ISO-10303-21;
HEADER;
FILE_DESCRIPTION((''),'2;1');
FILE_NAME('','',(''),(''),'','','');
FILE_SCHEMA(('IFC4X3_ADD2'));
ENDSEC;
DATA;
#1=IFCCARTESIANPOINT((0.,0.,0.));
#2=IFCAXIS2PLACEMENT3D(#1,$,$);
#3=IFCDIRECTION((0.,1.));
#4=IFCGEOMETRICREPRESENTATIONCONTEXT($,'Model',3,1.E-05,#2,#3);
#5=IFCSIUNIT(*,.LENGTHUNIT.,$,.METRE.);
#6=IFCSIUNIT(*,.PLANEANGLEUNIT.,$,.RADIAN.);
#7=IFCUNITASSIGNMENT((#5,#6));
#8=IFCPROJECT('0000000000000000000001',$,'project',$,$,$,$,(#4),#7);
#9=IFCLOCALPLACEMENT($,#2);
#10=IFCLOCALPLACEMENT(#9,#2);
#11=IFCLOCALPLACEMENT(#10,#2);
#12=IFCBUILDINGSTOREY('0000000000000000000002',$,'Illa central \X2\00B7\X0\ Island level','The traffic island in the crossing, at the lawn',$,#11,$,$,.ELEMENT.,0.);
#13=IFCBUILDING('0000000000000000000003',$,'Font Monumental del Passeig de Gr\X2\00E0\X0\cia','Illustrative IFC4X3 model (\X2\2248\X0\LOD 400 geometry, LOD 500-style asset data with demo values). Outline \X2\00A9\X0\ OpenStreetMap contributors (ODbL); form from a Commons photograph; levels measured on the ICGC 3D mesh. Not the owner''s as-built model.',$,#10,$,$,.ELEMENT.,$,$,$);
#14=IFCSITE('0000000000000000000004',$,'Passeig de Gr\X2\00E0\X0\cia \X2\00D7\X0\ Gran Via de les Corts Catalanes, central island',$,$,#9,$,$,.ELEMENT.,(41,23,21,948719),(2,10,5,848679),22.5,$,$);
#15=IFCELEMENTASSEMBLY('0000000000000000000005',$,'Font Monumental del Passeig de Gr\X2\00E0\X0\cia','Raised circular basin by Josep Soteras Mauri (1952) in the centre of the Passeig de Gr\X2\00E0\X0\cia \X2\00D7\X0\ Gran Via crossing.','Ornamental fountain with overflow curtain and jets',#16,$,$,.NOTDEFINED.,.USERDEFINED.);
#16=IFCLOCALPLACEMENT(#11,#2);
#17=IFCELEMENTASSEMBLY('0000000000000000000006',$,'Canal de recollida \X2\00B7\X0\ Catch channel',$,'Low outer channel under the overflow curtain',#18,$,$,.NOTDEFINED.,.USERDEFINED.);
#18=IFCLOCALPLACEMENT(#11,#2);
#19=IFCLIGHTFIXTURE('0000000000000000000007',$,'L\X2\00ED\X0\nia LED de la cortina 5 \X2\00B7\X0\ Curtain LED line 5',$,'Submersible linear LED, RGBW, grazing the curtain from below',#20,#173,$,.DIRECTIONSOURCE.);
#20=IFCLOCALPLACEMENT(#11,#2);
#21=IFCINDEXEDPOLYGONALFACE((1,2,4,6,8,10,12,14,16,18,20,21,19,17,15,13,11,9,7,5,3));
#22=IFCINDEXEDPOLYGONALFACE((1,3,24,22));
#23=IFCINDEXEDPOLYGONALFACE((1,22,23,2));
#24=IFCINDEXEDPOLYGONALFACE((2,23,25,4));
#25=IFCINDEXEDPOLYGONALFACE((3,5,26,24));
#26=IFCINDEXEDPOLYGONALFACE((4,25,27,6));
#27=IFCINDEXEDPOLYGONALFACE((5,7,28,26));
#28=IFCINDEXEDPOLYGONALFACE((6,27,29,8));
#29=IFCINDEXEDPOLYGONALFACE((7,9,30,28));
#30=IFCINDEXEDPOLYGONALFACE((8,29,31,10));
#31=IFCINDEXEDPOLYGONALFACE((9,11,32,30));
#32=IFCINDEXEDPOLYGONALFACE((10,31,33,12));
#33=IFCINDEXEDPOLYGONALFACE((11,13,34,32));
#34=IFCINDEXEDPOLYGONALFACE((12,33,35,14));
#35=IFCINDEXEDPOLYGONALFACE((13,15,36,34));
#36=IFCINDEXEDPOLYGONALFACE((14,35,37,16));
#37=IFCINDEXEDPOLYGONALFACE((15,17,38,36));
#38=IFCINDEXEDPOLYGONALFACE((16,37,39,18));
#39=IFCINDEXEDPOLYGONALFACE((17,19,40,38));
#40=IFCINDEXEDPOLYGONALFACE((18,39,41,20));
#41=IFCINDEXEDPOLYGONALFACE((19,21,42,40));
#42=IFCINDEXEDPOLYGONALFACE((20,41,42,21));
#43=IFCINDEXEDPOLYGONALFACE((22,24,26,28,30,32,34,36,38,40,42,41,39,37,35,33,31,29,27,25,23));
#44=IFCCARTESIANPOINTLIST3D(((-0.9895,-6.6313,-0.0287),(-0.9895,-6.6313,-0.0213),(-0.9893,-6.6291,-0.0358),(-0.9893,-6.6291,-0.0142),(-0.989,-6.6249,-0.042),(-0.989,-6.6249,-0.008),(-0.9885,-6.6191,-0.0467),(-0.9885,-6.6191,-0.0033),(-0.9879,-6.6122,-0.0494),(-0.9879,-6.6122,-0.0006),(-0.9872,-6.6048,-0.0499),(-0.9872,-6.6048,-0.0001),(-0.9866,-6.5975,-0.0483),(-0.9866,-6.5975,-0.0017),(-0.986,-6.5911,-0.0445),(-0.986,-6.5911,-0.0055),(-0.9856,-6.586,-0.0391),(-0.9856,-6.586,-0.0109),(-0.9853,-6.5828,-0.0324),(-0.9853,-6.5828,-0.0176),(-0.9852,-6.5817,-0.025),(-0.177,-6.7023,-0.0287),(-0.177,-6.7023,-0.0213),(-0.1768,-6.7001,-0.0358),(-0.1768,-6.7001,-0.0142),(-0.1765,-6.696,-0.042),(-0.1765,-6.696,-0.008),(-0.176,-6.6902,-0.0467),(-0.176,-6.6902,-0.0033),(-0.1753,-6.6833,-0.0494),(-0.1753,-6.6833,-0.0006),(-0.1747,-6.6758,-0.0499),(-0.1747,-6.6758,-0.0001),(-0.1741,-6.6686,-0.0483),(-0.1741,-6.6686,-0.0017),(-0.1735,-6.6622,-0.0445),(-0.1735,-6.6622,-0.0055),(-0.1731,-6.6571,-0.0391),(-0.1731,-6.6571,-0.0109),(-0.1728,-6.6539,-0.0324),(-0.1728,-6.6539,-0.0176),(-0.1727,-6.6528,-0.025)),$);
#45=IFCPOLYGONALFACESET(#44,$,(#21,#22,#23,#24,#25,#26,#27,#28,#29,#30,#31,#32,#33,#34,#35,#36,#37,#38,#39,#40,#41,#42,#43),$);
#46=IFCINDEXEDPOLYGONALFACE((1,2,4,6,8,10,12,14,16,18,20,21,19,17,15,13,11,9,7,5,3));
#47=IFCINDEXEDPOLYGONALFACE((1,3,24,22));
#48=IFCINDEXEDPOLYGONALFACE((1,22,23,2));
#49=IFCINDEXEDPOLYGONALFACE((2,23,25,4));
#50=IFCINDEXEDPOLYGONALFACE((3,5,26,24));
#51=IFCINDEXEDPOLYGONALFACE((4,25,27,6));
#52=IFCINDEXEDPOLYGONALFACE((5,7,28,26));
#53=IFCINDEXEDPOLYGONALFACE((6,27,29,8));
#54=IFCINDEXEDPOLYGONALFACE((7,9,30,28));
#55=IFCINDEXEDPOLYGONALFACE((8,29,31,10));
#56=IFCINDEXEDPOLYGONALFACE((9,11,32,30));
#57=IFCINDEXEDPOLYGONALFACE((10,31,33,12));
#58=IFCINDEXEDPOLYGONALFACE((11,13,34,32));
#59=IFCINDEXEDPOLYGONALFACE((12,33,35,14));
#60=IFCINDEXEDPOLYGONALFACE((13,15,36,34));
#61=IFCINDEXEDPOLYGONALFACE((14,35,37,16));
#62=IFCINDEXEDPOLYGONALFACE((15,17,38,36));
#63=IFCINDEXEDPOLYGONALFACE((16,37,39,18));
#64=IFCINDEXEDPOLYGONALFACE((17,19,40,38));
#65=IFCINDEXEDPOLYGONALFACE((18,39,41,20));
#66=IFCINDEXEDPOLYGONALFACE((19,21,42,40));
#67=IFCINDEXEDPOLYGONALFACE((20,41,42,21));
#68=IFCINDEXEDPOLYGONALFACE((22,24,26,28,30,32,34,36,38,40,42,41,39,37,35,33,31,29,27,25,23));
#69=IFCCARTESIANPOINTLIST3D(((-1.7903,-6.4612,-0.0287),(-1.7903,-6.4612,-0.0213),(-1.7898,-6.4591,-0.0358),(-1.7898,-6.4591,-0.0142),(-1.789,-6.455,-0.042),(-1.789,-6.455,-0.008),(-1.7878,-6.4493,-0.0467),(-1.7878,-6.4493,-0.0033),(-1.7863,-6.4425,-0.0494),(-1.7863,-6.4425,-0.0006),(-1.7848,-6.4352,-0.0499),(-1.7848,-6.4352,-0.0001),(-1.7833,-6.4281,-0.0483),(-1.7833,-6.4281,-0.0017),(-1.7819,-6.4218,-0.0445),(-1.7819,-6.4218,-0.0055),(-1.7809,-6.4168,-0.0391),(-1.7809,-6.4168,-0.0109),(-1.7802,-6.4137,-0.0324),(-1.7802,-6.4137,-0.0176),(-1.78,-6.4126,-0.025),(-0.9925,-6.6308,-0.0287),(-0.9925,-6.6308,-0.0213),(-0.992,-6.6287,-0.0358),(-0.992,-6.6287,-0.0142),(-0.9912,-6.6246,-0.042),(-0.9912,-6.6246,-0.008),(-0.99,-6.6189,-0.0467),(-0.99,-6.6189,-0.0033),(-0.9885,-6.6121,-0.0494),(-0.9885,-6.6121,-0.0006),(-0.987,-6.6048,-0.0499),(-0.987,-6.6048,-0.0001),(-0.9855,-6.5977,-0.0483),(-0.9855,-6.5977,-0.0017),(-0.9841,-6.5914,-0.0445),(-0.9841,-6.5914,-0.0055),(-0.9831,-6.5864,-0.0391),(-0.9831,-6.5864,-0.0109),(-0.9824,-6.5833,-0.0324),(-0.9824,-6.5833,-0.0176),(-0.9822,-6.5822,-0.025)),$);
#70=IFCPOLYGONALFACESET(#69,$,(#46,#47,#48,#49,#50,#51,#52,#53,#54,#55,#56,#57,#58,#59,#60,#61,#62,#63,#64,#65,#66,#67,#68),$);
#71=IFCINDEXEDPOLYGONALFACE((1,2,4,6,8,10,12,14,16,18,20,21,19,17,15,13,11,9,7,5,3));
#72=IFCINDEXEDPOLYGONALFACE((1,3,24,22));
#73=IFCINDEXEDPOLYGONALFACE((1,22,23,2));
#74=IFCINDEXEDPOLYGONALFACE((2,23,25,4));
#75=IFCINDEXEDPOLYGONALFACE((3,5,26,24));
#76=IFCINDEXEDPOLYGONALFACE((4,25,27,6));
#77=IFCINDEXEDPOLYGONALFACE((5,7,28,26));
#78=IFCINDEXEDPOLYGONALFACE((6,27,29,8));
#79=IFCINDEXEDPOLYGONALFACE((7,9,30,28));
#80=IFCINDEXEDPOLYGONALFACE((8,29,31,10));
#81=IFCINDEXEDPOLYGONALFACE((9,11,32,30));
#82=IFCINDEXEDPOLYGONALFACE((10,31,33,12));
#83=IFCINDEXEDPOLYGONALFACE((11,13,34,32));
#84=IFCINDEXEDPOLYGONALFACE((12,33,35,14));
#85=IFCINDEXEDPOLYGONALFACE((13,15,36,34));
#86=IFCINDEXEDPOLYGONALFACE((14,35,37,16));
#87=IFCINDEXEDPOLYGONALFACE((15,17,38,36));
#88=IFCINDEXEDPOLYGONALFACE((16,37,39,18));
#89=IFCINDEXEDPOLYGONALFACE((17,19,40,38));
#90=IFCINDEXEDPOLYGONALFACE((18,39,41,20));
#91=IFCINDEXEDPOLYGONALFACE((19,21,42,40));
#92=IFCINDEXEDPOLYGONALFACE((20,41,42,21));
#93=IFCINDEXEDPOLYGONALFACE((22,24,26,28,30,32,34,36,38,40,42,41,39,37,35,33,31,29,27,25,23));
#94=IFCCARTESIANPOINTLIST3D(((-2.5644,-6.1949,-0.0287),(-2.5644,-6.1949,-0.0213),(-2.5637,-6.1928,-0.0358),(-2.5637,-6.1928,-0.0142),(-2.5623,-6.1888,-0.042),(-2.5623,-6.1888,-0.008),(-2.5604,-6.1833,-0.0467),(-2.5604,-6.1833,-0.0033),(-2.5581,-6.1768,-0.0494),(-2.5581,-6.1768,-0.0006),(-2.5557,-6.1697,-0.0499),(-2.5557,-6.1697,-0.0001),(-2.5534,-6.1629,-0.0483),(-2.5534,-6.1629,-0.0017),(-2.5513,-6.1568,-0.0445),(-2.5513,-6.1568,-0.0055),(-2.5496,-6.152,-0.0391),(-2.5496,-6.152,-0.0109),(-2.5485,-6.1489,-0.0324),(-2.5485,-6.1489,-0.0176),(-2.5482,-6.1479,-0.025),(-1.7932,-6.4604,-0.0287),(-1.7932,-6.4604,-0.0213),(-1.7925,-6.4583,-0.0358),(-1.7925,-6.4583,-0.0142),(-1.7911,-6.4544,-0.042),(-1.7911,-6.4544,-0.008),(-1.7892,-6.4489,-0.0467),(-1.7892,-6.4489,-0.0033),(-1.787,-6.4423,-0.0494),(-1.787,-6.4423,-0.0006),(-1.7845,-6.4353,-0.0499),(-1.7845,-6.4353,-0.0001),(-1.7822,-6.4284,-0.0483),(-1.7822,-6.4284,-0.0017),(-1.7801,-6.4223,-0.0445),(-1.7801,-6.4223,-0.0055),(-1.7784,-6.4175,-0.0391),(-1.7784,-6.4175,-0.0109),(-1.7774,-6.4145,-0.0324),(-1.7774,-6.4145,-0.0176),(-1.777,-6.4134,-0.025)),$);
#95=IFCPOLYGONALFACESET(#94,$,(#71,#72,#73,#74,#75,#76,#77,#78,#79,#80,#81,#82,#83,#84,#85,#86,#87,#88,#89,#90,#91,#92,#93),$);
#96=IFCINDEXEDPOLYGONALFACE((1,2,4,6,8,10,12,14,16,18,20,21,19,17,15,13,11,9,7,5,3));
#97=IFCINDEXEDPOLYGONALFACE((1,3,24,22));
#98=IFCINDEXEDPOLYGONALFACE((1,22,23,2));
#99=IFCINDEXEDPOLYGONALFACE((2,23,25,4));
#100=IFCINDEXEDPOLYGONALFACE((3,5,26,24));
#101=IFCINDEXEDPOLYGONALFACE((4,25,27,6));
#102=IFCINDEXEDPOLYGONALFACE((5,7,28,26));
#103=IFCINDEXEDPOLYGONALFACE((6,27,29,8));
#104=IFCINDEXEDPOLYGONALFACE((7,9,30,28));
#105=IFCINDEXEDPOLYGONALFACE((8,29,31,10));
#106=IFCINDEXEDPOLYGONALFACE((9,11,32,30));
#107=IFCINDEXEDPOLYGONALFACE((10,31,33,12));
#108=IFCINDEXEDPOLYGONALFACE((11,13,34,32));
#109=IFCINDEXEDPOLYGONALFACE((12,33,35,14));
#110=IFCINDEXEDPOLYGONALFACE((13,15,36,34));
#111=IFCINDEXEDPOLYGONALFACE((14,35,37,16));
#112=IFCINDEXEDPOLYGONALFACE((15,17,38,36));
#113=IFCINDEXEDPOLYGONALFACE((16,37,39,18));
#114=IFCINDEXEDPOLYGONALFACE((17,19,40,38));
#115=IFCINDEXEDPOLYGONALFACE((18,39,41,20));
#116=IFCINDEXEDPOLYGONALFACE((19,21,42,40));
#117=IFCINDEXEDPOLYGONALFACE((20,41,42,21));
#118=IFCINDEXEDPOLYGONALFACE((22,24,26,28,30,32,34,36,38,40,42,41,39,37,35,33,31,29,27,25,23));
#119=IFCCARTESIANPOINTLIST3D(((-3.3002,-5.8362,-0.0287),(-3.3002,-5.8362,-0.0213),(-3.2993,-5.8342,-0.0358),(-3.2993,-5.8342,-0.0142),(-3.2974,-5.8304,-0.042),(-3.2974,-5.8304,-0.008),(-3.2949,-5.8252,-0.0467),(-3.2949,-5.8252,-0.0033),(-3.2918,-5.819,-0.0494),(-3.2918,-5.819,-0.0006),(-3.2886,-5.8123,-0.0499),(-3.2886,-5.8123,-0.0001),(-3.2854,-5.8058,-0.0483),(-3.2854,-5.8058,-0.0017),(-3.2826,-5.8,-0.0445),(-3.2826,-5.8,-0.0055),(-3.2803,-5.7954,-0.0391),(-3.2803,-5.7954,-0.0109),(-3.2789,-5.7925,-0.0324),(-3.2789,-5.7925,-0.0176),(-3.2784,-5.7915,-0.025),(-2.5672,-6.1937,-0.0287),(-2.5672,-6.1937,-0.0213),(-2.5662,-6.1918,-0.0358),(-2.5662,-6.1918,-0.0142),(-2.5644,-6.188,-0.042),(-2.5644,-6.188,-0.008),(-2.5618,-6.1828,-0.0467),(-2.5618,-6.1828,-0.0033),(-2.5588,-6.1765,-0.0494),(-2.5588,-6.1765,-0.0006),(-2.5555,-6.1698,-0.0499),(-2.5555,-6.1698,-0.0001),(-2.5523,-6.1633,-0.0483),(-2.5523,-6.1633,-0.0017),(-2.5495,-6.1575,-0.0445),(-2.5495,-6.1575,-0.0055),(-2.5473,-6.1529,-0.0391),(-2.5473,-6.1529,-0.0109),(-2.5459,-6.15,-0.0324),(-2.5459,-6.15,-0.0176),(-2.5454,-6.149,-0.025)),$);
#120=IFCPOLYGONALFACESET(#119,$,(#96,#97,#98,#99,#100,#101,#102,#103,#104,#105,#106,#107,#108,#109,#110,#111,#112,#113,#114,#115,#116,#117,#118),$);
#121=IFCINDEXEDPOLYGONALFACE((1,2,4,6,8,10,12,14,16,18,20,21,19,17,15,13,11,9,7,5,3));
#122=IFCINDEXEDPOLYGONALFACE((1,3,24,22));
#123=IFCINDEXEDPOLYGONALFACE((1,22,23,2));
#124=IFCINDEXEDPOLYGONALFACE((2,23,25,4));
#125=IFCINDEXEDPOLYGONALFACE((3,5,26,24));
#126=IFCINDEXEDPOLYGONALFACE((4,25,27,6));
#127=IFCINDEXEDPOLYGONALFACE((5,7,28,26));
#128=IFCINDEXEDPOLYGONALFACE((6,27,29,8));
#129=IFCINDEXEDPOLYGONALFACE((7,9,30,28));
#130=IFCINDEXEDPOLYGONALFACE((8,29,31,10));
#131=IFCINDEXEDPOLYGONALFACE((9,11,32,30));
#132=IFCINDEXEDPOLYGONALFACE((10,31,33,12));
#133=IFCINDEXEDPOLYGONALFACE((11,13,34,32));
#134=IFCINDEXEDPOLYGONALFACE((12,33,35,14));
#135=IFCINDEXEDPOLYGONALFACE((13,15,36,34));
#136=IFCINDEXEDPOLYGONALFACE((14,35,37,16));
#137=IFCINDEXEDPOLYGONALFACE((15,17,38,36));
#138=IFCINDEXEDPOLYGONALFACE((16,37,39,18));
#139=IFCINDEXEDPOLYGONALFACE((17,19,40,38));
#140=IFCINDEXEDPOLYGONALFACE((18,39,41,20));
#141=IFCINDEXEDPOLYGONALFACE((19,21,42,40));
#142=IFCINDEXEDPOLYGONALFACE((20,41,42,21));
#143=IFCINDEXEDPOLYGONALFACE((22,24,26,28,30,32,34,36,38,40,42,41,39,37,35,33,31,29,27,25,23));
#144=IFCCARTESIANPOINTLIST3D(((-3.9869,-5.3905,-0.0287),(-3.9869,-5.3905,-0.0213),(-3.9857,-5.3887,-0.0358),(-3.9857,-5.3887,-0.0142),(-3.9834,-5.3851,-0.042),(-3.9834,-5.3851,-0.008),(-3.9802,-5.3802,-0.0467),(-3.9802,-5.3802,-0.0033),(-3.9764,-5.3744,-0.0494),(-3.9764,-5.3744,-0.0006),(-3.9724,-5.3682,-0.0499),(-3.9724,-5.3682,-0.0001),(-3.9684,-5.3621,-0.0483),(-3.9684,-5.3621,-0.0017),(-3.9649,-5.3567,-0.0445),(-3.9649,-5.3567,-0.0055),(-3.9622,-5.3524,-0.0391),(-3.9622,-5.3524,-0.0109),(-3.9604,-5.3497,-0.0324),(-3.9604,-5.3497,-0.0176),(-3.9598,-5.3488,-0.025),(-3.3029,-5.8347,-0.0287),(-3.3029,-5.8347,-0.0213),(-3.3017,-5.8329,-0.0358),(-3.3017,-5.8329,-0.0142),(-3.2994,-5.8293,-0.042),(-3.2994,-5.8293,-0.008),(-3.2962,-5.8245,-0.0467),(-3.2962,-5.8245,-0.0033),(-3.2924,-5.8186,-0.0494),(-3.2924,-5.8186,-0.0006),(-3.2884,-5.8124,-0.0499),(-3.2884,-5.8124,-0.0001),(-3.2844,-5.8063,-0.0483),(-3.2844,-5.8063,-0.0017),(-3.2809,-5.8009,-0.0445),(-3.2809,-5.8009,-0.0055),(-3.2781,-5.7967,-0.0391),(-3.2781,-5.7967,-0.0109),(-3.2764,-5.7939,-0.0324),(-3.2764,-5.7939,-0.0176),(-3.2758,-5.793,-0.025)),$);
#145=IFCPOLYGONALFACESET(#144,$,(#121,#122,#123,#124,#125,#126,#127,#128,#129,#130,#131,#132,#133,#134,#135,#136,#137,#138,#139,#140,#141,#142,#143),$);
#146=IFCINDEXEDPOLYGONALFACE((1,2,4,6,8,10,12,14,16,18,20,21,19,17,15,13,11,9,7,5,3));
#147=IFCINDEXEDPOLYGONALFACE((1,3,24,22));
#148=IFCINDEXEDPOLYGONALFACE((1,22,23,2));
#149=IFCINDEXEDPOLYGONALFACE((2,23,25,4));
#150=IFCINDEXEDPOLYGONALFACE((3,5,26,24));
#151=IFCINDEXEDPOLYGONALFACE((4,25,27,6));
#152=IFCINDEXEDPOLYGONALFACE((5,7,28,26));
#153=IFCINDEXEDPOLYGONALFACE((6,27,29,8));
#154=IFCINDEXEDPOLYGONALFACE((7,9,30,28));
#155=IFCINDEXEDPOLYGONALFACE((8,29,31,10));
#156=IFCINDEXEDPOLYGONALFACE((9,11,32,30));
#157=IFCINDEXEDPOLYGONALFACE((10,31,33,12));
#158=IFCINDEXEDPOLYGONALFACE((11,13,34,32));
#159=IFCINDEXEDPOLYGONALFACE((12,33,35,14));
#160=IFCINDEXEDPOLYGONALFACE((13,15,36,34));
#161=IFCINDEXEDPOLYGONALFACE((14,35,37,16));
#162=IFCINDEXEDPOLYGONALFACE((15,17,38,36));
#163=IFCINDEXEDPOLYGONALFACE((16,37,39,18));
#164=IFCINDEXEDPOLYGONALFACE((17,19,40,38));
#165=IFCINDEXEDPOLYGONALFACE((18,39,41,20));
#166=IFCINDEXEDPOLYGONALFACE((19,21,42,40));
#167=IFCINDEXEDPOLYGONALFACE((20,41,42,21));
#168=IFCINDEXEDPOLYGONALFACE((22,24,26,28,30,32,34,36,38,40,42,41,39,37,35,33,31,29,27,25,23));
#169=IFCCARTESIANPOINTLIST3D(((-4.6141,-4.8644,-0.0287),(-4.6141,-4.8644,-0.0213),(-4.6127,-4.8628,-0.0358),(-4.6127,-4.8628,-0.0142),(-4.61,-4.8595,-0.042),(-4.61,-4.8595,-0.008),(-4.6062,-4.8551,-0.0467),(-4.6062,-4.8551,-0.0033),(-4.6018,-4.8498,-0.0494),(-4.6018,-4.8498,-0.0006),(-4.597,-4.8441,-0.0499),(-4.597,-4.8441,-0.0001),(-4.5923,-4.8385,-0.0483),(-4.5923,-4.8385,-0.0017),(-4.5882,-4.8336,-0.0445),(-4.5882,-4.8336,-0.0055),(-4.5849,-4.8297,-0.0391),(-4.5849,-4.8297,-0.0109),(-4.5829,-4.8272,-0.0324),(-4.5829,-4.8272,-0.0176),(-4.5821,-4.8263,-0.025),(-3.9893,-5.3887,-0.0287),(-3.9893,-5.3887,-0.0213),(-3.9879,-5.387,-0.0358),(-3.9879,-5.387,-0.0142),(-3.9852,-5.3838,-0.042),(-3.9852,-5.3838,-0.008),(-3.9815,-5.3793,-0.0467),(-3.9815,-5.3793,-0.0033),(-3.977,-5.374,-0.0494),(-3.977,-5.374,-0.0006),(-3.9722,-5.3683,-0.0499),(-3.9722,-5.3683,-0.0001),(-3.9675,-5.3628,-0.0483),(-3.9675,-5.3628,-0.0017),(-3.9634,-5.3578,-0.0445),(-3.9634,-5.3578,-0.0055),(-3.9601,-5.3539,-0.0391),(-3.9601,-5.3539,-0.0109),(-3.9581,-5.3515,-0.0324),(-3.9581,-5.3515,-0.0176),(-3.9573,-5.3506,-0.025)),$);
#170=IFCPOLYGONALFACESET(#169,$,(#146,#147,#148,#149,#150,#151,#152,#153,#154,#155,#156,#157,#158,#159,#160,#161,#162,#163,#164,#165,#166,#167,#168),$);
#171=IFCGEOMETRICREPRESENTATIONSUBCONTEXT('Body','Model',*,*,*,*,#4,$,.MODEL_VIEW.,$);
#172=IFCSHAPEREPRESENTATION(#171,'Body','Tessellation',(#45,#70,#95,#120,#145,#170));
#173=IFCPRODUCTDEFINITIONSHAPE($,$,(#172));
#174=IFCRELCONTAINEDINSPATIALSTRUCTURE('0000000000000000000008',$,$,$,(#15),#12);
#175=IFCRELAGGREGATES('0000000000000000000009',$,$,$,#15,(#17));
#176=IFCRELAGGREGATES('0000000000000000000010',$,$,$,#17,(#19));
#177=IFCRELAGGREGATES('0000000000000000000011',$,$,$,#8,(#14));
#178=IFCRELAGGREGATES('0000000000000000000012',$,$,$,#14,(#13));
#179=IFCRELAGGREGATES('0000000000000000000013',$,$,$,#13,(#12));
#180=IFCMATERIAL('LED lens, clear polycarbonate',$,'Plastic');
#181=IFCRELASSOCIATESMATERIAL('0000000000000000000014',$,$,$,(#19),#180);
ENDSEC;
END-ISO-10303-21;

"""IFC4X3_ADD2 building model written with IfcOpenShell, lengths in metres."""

from ifc_helpers import new_model, si_unit, direction, frame, origin, origin_2d_with_axis, place, context, subcontext, project, spatial, circle, extrude, material, element, aggregate, save


model = new_model("IFC4X3_ADD2")

# Units and contexts
model_context = context("Model", 3, precision=1e-05, world=origin(), true_north=direction((0.0, 1.0)))
body_context = subcontext(model_context, "Body", "Model", "MODEL_VIEW")
ifc_project = project(units=[si_unit("LENGTHUNIT", "METRE"), si_unit("PLANEANGLEUNIT", "RADIAN")], contexts=[model_context])

# Site, building, storey
site_placement = place(None, origin())
site = spatial("IfcSite", under=ifc_project, at=site_placement, Name="Passeig de Gràcia × Gran Via de les Corts Catalanes, central island", CompositionType="ELEMENT", RefLatitude=(41, 23, 21, 948719), RefLongitude=(2, 10, 5, 848679), RefElevation=22.5)
building_placement = place(site_placement, origin())
building = spatial("IfcBuilding", under=site, at=building_placement, Name="Font Monumental del Passeig de Gràcia", Description="Illustrative IFC4X3 model (≈LOD 400 geometry, LOD 500-style asset data with demo values). Outline © OpenStreetMap contributors (ODbL); form from a Commons photograph; levels measured on the ICGC 3D mesh. Not the owner's as-built model.", CompositionType="ELEMENT")
storey_placement = place(building_placement, origin())
storey = spatial("IfcBuildingStorey", under=building, at=storey_placement, Name="Illa central · Island level", Description="The traffic island in the crossing, at the lawn", CompositionType="ELEMENT", Elevation=0.0)

# Element assemblies, light fixture
assembly_1_placement = place(building_placement, origin())
assembly_1 = element("IfcElementAssembly", 1, at=assembly_1_placement, inside=storey, Name="Font Monumental del Passeig de Gràcia", Description="Raised circular basin by Josep Soteras Mauri (1952) in the centre of the Passeig de Gràcia × Gran Via crossing.", ObjectType="Ornamental fountain with overflow curtain and jets", AssemblyPlace="NOTDEFINED", PredefinedType="USERDEFINED")
assembly_2_placement = place(building_placement, origin())
assembly_2 = element("IfcElementAssembly", 2, at=assembly_2_placement, Name="Canal de recollida · Catch channel", ObjectType="Low outer channel under the overflow curtain", AssemblyPlace="NOTDEFINED", PredefinedType="USERDEFINED")
ifc_material_1 = material(Name="LED lens, clear polycarbonate", Category="Plastic")
light_fixture_1_placement = place(building_placement, origin())
light_fixture_1 = element("IfcLightFixture", 3, at=light_fixture_1_placement, material=ifc_material_1, Name="Línia LED de la cortina 5 · Curtain LED line 5", ObjectType="Submersible linear LED, RGBW, grazing the curtain from below", PredefinedType="DIRECTIONSOURCE", context=body_context, shape_type="SweptSolid", body=[
    extrude(circle(Radius=0.025, at=origin_2d_with_axis()), frame((-0.1749, -6.6777, -0.025), z_axis=(-0.996195, 0.087156, 0.0), x_axis=(0.087156, 0.996195, 0.0)), (0.0, 0.0, 1.0), 0.8156),
    extrude(circle(Radius=0.025, at=origin_2d_with_axis()), frame((-0.9874, -6.6066, -0.025), z_axis=(-0.978148, 0.207912, 0.0), x_axis=(0.207912, 0.978148, 0.0)), (0.0, 0.0, 1.0), 0.8156),
    extrude(circle(Radius=0.025, at=origin_2d_with_axis()), frame((-1.7852, -6.4371, -0.025), z_axis=(-0.945519, 0.325568, 0.0), x_axis=(0.325568, 0.945519, 0.0)), (0.0, 0.0, 1.0), 0.8156),
    extrude(circle(Radius=0.025, at=origin_2d_with_axis()), frame((-2.5563, -6.1715, -0.025), z_axis=(-0.898794, 0.438371, 0.0), x_axis=(0.438371, 0.898794, 0.0)), (0.0, 0.0, 1.0), 0.8156),
    extrude(circle(Radius=0.025, at=origin_2d_with_axis()), frame((-3.2894, -5.814, -0.025), z_axis=(-0.838671, 0.544639, 0.0), x_axis=(0.544639, 0.838671, 0.0)), (0.0, 0.0, 1.0), 0.8156),
    extrude(circle(Radius=0.025, at=origin_2d_with_axis()), frame((-3.9734, -5.3698, -0.025), z_axis=(-0.766044, 0.642788, 0.0), x_axis=(0.642788, 0.766044, 0.0)), (0.0, 0.0, 1.0), 0.8156),
])
aggregate(assembly_1, [assembly_2])
aggregate(assembly_2, [light_fixture_1])

save(model, "model.ifc")
